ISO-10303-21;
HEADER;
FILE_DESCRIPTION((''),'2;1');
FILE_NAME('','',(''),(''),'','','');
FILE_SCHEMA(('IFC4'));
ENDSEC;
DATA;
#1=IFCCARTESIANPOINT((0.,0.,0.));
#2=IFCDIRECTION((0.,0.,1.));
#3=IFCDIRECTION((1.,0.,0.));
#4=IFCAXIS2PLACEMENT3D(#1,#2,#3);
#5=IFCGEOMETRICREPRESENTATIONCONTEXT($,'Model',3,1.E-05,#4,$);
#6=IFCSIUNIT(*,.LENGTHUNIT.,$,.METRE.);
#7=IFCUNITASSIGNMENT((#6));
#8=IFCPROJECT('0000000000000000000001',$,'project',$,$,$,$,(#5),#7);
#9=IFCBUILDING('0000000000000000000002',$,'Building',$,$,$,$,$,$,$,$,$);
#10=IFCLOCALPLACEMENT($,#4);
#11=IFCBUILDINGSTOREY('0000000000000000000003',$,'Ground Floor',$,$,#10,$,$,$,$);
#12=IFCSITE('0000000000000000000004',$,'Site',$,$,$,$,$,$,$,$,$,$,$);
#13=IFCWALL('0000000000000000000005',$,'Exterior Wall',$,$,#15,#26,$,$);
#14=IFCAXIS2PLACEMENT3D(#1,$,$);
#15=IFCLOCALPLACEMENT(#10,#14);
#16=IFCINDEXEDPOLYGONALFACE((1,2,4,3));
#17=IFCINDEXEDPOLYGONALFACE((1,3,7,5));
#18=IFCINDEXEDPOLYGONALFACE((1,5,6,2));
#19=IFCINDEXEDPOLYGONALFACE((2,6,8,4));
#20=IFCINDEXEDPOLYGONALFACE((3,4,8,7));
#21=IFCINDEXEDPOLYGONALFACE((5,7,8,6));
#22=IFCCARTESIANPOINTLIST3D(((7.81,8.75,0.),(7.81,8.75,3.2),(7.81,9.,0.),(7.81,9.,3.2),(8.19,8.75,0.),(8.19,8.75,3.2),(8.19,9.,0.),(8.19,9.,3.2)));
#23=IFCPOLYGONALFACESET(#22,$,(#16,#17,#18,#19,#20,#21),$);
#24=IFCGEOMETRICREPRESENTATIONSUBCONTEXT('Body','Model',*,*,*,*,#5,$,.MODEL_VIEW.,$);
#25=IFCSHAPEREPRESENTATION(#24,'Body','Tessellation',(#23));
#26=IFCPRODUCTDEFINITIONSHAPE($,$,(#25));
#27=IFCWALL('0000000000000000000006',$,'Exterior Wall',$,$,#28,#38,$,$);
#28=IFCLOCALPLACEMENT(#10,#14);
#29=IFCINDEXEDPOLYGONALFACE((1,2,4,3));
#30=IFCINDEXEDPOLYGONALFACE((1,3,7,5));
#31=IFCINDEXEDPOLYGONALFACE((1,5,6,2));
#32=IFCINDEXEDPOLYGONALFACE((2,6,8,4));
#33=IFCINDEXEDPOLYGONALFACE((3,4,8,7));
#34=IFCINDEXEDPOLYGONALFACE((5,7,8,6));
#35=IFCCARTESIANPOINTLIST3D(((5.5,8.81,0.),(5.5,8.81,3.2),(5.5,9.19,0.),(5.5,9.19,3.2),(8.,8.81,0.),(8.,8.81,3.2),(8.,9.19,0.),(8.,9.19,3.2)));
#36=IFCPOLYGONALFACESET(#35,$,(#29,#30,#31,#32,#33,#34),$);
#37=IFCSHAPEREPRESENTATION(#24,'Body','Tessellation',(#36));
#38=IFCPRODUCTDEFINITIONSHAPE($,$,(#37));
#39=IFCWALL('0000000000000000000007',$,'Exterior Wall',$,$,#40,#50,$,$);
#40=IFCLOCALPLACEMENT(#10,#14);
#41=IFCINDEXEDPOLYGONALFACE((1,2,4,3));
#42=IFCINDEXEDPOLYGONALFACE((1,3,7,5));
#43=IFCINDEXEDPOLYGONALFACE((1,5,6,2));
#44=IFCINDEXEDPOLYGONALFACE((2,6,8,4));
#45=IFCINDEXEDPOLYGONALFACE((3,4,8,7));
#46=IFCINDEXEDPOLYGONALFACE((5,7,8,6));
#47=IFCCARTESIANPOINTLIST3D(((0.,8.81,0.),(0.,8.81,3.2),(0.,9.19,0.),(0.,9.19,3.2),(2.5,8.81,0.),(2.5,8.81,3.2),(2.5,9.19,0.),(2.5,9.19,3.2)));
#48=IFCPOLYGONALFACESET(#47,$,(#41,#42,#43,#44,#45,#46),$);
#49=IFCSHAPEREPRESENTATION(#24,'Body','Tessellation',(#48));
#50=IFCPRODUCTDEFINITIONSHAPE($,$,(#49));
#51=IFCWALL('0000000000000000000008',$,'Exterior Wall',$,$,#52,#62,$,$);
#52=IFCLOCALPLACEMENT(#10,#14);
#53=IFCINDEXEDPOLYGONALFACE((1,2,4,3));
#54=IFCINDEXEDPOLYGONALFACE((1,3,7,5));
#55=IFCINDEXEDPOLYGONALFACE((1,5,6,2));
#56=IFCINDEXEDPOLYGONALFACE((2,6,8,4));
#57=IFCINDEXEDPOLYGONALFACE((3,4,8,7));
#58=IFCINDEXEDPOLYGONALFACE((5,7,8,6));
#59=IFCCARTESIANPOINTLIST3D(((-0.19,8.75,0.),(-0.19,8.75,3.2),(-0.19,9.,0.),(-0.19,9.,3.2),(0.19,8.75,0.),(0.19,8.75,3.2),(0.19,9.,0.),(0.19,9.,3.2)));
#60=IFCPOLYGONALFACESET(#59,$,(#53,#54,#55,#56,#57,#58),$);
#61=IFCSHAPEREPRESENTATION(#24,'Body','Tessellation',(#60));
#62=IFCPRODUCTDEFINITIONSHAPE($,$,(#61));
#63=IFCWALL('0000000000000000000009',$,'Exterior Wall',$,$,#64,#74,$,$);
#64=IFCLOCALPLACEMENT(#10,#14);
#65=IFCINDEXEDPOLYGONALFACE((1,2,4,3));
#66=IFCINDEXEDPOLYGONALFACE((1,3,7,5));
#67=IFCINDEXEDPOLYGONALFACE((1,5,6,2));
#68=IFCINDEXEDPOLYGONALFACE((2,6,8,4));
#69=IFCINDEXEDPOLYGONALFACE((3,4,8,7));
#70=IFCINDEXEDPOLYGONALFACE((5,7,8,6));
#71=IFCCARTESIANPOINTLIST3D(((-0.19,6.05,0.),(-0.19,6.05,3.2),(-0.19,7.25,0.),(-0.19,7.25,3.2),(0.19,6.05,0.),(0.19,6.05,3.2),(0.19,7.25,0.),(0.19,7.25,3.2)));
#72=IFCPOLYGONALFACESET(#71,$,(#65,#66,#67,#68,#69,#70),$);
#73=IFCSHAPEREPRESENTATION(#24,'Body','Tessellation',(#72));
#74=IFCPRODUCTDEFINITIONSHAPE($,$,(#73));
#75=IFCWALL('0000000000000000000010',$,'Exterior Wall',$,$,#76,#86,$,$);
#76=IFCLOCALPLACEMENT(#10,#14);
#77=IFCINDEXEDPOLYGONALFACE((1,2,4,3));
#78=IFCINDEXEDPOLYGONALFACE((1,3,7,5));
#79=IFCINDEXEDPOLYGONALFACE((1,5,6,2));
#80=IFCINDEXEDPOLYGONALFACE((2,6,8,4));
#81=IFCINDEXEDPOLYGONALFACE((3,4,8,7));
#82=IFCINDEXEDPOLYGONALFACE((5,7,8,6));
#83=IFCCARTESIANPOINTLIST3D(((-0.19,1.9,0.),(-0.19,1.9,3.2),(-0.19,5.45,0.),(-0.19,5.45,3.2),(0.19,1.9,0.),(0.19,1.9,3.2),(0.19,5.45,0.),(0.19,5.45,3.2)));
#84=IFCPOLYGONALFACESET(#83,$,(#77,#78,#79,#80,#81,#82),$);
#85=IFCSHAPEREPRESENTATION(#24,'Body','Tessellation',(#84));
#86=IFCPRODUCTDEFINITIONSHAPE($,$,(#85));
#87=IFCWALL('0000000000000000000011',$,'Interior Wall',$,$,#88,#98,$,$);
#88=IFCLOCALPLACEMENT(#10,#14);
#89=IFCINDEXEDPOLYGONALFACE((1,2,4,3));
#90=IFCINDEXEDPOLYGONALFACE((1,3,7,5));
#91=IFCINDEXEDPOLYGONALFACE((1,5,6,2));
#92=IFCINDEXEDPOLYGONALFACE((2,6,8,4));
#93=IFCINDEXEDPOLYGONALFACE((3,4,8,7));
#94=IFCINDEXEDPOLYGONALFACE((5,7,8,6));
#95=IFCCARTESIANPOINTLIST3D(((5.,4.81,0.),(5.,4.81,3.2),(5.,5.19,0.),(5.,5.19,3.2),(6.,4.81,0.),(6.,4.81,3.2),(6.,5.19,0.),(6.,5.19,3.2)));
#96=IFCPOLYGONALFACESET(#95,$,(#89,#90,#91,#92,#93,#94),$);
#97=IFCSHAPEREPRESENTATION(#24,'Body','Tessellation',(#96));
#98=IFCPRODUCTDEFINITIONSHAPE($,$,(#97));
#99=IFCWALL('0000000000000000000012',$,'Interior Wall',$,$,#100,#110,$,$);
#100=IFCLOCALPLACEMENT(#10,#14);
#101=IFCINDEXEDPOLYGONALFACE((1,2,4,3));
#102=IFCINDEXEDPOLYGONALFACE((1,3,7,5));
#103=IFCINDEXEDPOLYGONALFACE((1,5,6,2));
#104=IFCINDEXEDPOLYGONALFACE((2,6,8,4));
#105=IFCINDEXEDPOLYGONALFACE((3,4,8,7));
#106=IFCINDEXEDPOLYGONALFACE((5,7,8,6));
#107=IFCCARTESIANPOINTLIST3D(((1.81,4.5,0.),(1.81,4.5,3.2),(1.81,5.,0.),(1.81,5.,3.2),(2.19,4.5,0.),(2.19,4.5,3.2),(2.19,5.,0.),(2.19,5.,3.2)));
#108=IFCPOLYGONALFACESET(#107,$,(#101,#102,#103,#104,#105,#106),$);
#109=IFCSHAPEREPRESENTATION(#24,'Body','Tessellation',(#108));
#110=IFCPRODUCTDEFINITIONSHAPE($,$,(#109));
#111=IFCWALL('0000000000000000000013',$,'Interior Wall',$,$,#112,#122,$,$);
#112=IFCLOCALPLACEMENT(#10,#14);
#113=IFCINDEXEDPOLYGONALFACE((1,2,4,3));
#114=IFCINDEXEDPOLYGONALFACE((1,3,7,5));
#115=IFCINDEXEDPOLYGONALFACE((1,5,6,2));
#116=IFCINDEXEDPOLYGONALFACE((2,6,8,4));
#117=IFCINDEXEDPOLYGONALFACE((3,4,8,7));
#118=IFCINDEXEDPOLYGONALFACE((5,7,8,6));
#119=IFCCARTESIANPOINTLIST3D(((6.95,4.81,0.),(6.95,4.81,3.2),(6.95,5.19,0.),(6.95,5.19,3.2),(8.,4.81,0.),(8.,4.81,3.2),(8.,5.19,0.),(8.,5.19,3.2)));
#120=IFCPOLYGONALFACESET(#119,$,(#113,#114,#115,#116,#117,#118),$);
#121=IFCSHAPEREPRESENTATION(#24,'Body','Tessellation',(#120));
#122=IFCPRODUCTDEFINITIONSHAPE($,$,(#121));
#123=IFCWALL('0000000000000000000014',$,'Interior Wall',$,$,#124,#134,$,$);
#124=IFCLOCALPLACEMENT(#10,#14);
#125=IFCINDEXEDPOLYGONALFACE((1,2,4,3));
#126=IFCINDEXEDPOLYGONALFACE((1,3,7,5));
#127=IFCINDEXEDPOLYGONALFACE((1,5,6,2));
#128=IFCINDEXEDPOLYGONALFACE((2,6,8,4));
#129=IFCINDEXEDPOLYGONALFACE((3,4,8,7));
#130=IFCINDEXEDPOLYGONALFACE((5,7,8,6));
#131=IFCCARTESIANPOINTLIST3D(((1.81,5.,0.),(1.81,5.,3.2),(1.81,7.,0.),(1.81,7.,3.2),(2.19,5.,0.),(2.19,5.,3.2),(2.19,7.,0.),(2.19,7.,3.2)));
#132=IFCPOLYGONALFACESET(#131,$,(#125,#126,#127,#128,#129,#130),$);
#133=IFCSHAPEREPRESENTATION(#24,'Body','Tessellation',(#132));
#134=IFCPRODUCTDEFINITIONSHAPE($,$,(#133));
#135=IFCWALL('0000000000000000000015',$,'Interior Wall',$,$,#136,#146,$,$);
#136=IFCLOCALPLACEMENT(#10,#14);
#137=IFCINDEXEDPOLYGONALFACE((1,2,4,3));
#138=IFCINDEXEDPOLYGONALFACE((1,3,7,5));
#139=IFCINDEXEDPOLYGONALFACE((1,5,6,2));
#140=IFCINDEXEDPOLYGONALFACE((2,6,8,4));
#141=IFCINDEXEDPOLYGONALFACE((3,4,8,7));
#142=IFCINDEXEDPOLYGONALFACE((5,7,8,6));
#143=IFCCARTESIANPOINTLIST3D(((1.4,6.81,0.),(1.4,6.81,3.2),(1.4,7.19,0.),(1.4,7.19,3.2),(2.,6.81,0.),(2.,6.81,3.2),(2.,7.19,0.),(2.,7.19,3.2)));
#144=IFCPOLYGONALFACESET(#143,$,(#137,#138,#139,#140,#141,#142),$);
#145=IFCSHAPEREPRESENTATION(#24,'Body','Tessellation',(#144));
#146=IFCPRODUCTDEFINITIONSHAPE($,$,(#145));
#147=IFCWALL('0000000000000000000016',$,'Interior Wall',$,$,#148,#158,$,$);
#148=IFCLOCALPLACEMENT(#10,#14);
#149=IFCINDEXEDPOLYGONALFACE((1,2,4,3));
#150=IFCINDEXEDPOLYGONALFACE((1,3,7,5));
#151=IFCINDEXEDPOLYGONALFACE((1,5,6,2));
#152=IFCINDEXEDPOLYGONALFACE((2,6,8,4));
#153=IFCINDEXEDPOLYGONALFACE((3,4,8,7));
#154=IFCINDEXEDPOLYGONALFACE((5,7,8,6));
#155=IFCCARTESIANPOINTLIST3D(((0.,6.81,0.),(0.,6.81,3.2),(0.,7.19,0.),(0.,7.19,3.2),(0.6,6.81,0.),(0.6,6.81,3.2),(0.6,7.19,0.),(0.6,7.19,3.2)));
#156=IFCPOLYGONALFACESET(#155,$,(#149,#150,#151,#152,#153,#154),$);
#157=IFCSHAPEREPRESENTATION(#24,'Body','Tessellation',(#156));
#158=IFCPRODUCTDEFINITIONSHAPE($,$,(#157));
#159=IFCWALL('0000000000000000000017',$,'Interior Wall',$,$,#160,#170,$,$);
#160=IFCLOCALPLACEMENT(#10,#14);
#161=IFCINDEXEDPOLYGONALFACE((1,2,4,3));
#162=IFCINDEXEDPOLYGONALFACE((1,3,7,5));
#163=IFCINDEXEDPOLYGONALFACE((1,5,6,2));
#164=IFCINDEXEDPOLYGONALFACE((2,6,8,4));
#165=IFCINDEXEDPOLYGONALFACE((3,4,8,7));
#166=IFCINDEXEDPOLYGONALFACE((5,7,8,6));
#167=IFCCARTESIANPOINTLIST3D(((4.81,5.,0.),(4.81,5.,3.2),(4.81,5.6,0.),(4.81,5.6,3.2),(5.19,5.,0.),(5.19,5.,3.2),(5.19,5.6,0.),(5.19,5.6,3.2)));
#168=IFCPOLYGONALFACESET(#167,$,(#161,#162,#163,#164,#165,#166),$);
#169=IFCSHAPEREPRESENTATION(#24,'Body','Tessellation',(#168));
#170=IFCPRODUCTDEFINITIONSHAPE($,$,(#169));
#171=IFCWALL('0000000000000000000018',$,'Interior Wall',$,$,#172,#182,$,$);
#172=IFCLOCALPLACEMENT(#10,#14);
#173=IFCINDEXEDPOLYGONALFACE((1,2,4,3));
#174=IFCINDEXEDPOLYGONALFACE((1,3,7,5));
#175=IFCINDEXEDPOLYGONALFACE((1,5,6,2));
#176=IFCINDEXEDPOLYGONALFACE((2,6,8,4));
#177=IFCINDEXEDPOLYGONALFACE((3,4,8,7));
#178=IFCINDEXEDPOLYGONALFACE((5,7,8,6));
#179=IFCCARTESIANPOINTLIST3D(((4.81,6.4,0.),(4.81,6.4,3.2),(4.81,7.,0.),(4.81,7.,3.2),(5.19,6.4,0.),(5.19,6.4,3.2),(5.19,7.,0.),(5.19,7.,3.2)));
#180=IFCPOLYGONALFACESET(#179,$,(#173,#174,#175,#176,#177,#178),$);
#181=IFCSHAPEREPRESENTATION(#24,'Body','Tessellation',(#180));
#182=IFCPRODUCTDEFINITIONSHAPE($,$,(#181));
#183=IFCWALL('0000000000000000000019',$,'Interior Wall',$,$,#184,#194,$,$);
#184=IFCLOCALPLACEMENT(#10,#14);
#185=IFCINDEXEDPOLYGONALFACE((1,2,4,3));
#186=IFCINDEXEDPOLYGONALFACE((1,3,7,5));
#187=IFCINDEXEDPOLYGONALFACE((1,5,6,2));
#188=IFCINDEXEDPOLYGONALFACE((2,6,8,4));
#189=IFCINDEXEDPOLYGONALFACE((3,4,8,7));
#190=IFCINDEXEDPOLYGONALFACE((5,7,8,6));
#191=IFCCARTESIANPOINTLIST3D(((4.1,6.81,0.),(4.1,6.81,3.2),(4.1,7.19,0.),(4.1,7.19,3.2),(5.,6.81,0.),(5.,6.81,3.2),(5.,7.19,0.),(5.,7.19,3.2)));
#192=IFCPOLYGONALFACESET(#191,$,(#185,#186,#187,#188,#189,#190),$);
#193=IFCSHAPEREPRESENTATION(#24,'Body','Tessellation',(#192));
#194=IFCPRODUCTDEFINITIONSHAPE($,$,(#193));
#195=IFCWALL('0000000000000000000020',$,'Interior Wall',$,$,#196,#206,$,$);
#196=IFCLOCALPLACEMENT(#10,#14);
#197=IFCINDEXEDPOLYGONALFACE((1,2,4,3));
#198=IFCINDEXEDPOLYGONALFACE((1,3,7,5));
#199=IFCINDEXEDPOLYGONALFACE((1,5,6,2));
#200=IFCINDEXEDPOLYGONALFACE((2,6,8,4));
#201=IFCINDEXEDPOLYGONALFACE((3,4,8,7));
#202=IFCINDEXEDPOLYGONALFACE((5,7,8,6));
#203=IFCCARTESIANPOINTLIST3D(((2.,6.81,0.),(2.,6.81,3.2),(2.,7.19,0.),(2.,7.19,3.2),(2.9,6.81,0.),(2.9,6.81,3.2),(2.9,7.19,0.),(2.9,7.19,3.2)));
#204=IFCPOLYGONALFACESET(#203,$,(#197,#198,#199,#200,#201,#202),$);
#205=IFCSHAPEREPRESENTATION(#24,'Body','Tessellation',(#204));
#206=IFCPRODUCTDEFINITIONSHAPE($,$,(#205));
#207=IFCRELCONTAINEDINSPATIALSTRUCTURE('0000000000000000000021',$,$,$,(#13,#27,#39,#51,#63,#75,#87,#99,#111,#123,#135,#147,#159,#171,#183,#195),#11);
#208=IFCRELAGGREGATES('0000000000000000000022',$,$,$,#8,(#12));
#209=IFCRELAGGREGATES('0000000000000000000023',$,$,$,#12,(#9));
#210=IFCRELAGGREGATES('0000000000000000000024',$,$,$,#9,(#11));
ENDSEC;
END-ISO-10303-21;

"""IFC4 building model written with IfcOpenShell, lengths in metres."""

from ifc_helpers import new_model, si_unit, frame, origin_with_axes, place, context, subcontext, project, spatial, indexed_curve, outline, extrude, element, save


model = new_model("IFC4")

# Units and contexts
model_context = context("Model", 3, precision=1e-05, world=origin_with_axes())
body_context = subcontext(model_context, "Body", "Model", "MODEL_VIEW")
ifc_project = project(units=[si_unit("LENGTHUNIT", "METRE")], contexts=[model_context])

# Site, building, storey
site = spatial("IfcSite", under=ifc_project, Name="Site")
building = spatial("IfcBuilding", under=site, Name="Building")
storey_placement = place(None, origin_with_axes())
storey = spatial("IfcBuildingStorey", under=building, at=storey_placement, Name="Ground Floor")

# Walls
wall_1_placement = place(storey_placement, frame((8.0, 8.75, 0.0), z_axis=(0.0, 0.0, 1.0), x_axis=(0.0, 1.0, 0.0)))
element("IfcWall", 1, at=wall_1_placement, inside=storey, Name="Exterior Wall", context=body_context, shape_type="SweptSolid", body=[
    extrude(outline(indexed_curve([(0.0, 0.0), (0.0, 0.38), (0.25, 0.38), (0.25, 0.0), (0.0, 0.0)], self_intersect=False)), frame((0.0, -0.19, 0.0), z_axis=(0.0, 0.0, 1.0), x_axis=(1.0, 0.0, 0.0)), (0.0, 0.0, 1.0), 3.2),
])
for number, where, z_axis, x_axis, name in (
    (2, (8.0, 9.0, 0.0), (0.0, 0.0, 1.0), (-1.0, 0.0, 0.0), "Exterior Wall"),
    (3, (2.5, 9.0, 0.0), (0.0, 0.0, 1.0), (-1.0, 0.0, 0.0), "Exterior Wall"),
):
    element("IfcWall", number, at=place(storey_placement, frame(where, z_axis=z_axis, x_axis=x_axis)), inside=storey, Name=name, context=body_context, shape_type="SweptSolid", body=[
        extrude(outline(indexed_curve([(0.0, 0.0), (0.0, 0.38), (2.5, 0.38), (2.5, 0.0), (0.0, 0.0)], self_intersect=False)), frame((0.0, -0.19, 0.0), z_axis=(0.0, 0.0, 1.0), x_axis=(1.0, 0.0, 0.0)), (0.0, 0.0, 1.0), 3.2),
    ])
wall_2_placement = place(storey_placement, frame((0.0, 9.0, 0.0), z_axis=(0.0, 0.0, 1.0), x_axis=(0.0, -1.0, 0.0)))
element("IfcWall", 4, at=wall_2_placement, inside=storey, Name="Exterior Wall", context=body_context, shape_type="SweptSolid", body=[
    extrude(outline(indexed_curve([(0.0, 0.0), (0.0, 0.38), (0.25, 0.38), (0.25, 0.0), (0.0, 0.0)], self_intersect=False)), frame((0.0, -0.19, 0.0), z_axis=(0.0, 0.0, 1.0), x_axis=(1.0, 0.0, 0.0)), (0.0, 0.0, 1.0), 3.2),
])
wall_3_placement = place(storey_placement, frame((0.0, 7.25, 0.0), z_axis=(0.0, 0.0, 1.0), x_axis=(0.0, -1.0, 0.0)))
element("IfcWall", 5, at=wall_3_placement, inside=storey, Name="Exterior Wall", context=body_context, shape_type="SweptSolid", body=[
    extrude(outline(indexed_curve([(0.0, 0.0), (0.0, 0.38), (1.2, 0.38), (1.2, 0.0), (0.0, 0.0)], self_intersect=False)), frame((0.0, -0.19, 0.0), z_axis=(0.0, 0.0, 1.0), x_axis=(1.0, 0.0, 0.0)), (0.0, 0.0, 1.0), 3.2),
])
wall_4_placement = place(storey_placement, frame((0.0, 5.45, 0.0), z_axis=(0.0, 0.0, 1.0), x_axis=(0.0, -1.0, 0.0)))
element("IfcWall", 6, at=wall_4_placement, inside=storey, Name="Exterior Wall", context=body_context, shape_type="SweptSolid", body=[
    extrude(outline(indexed_curve([(0.0, 0.0), (0.0, 0.38), (3.55, 0.38), (3.55, 0.0), (0.0, 0.0)], self_intersect=False)), frame((0.0, -0.19, 0.0), z_axis=(0.0, 0.0, 1.0), x_axis=(1.0, 0.0, 0.0)), (0.0, 0.0, 1.0), 3.2),
])
wall_5_placement = place(storey_placement, frame((6.0, 5.0, 0.0), z_axis=(0.0, 0.0, 1.0), x_axis=(-1.0, 0.0, 0.0)))
element("IfcWall", 7, at=wall_5_placement, inside=storey, Name="Interior Wall", context=body_context, shape_type="SweptSolid", body=[
    extrude(outline(indexed_curve([(0.0, 0.0), (0.0, 0.38), (1.0, 0.38), (1.0, 0.0), (0.0, 0.0)], self_intersect=False)), frame((0.0, -0.19, 0.0), z_axis=(0.0, 0.0, 1.0), x_axis=(1.0, 0.0, 0.0)), (0.0, 0.0, 1.0), 3.2),
])
wall_6_placement = place(storey_placement, frame((2.0, 5.0, 0.0), z_axis=(0.0, 0.0, 1.0), x_axis=(0.0, -1.0, 0.0)))
element("IfcWall", 8, at=wall_6_placement, inside=storey, Name="Interior Wall", context=body_context, shape_type="SweptSolid", body=[
    extrude(outline(indexed_curve([(0.0, 0.0), (0.0, 0.38), (0.5, 0.38), (0.5, 0.0), (0.0, 0.0)], self_intersect=False)), frame((0.0, -0.19, 0.0), z_axis=(0.0, 0.0, 1.0), x_axis=(1.0, 0.0, 0.0)), (0.0, 0.0, 1.0), 3.2),
])
wall_7_placement = place(storey_placement, frame((8.0, 5.0, 0.0), z_axis=(0.0, 0.0, 1.0), x_axis=(-1.0, 0.0, 0.0)))
element("IfcWall", 9, at=wall_7_placement, inside=storey, Name="Interior Wall", context=body_context, shape_type="SweptSolid", body=[
    extrude(outline(indexed_curve([(0.0, 0.0), (0.0, 0.38), (1.05, 0.38), (1.05, 0.0), (0.0, 0.0)], self_intersect=False)), frame((0.0, -0.19, 0.0), z_axis=(0.0, 0.0, 1.0), x_axis=(1.0, 0.0, 0.0)), (0.0, 0.0, 1.0), 3.2),
])
wall_8_placement = place(storey_placement, frame((2.0, 5.0, 0.0), z_axis=(0.0, 0.0, 1.0), x_axis=(0.0, 1.0, 0.0)))
element("IfcWall", 10, at=wall_8_placement, inside=storey, Name="Interior Wall", context=body_context, shape_type="SweptSolid", body=[
    extrude(outline(indexed_curve([(0.0, 0.0), (0.0, 0.38), (2.0, 0.38), (2.0, 0.0), (0.0, 0.0)], self_intersect=False)), frame((0.0, -0.19, 0.0), z_axis=(0.0, 0.0, 1.0), x_axis=(1.0, 0.0, 0.0)), (0.0, 0.0, 1.0), 3.2),
])
for number, where, z_axis, x_axis, name in (
    (11, (2.0, 7.0, 0.0), (0.0, 0.0, 1.0), (-1.0, 0.0, 0.0), "Interior Wall"),
    (12, (0.6, 7.0, 0.0), (0.0, 0.0, 1.0), (-1.0, 0.0, 0.0), "Interior Wall"),
):
    element("IfcWall", number, at=place(storey_placement, frame(where, z_axis=z_axis, x_axis=x_axis)), inside=storey, Name=name, context=body_context, shape_type="SweptSolid", body=[
        extrude(outline(indexed_curve([(0.0, 0.0), (0.0, 0.38), (0.6, 0.38), (0.6, 0.0), (0.0, 0.0)], self_intersect=False)), frame((0.0, -0.19, 0.0), z_axis=(0.0, 0.0, 1.0), x_axis=(1.0, 0.0, 0.0)), (0.0, 0.0, 1.0), 3.2),
    ])
for number, where, z_axis, x_axis, name in (
    (13, (5.0, 5.0, 0.0), (0.0, 0.0, 1.0), (0.0, 1.0, 0.0), "Interior Wall"),
    (14, (5.0, 6.4, 0.0), (0.0, 0.0, 1.0), (0.0, 1.0, 0.0), "Interior Wall"),
):
    element("IfcWall", number, at=place(storey_placement, frame(where, z_axis=z_axis, x_axis=x_axis)), inside=storey, Name=name, context=body_context, shape_type="SweptSolid", body=[
        extrude(outline(indexed_curve([(0.0, 0.0), (0.0, 0.38), (0.6, 0.38), (0.6, 0.0), (0.0, 0.0)], self_intersect=False)), frame((0.0, -0.19, 0.0), z_axis=(0.0, 0.0, 1.0), x_axis=(1.0, 0.0, 0.0)), (0.0, 0.0, 1.0), 3.2),
    ])
wall_9_placement = place(storey_placement, frame((5.0, 7.0, 0.0), z_axis=(0.0, 0.0, 1.0), x_axis=(-1.0, 0.0, 0.0)))
element("IfcWall", 15, at=wall_9_placement, inside=storey, Name="Interior Wall", context=body_context, shape_type="SweptSolid", body=[
    extrude(outline(indexed_curve([(0.0, 0.0), (0.0, 0.38), (0.9, 0.38), (0.9, 0.0), (0.0, 0.0)], self_intersect=False)), frame((0.0, -0.19, 0.0), z_axis=(0.0, 0.0, 1.0), x_axis=(1.0, 0.0, 0.0)), (0.0, 0.0, 1.0), 3.2),
])
wall_10_placement = place(storey_placement, frame((2.9, 7.0, 0.0), z_axis=(0.0, 0.0, 1.0), x_axis=(-1.0, 0.0, 0.0)))
element("IfcWall", 16, at=wall_10_placement, inside=storey, Name="Interior Wall", context=body_context, shape_type="SweptSolid", body=[
    extrude(outline(indexed_curve([(0.0, 0.0), (0.0, 0.38), (0.9, 0.38), (0.9, 0.0), (0.0, 0.0)], self_intersect=False)), frame((0.0, -0.19, 0.0), z_axis=(0.0, 0.0, 1.0), x_axis=(1.0, 0.0, 0.0)), (0.0, 0.0, 1.0), 3.2),
])

save(model, "model.ifc")
